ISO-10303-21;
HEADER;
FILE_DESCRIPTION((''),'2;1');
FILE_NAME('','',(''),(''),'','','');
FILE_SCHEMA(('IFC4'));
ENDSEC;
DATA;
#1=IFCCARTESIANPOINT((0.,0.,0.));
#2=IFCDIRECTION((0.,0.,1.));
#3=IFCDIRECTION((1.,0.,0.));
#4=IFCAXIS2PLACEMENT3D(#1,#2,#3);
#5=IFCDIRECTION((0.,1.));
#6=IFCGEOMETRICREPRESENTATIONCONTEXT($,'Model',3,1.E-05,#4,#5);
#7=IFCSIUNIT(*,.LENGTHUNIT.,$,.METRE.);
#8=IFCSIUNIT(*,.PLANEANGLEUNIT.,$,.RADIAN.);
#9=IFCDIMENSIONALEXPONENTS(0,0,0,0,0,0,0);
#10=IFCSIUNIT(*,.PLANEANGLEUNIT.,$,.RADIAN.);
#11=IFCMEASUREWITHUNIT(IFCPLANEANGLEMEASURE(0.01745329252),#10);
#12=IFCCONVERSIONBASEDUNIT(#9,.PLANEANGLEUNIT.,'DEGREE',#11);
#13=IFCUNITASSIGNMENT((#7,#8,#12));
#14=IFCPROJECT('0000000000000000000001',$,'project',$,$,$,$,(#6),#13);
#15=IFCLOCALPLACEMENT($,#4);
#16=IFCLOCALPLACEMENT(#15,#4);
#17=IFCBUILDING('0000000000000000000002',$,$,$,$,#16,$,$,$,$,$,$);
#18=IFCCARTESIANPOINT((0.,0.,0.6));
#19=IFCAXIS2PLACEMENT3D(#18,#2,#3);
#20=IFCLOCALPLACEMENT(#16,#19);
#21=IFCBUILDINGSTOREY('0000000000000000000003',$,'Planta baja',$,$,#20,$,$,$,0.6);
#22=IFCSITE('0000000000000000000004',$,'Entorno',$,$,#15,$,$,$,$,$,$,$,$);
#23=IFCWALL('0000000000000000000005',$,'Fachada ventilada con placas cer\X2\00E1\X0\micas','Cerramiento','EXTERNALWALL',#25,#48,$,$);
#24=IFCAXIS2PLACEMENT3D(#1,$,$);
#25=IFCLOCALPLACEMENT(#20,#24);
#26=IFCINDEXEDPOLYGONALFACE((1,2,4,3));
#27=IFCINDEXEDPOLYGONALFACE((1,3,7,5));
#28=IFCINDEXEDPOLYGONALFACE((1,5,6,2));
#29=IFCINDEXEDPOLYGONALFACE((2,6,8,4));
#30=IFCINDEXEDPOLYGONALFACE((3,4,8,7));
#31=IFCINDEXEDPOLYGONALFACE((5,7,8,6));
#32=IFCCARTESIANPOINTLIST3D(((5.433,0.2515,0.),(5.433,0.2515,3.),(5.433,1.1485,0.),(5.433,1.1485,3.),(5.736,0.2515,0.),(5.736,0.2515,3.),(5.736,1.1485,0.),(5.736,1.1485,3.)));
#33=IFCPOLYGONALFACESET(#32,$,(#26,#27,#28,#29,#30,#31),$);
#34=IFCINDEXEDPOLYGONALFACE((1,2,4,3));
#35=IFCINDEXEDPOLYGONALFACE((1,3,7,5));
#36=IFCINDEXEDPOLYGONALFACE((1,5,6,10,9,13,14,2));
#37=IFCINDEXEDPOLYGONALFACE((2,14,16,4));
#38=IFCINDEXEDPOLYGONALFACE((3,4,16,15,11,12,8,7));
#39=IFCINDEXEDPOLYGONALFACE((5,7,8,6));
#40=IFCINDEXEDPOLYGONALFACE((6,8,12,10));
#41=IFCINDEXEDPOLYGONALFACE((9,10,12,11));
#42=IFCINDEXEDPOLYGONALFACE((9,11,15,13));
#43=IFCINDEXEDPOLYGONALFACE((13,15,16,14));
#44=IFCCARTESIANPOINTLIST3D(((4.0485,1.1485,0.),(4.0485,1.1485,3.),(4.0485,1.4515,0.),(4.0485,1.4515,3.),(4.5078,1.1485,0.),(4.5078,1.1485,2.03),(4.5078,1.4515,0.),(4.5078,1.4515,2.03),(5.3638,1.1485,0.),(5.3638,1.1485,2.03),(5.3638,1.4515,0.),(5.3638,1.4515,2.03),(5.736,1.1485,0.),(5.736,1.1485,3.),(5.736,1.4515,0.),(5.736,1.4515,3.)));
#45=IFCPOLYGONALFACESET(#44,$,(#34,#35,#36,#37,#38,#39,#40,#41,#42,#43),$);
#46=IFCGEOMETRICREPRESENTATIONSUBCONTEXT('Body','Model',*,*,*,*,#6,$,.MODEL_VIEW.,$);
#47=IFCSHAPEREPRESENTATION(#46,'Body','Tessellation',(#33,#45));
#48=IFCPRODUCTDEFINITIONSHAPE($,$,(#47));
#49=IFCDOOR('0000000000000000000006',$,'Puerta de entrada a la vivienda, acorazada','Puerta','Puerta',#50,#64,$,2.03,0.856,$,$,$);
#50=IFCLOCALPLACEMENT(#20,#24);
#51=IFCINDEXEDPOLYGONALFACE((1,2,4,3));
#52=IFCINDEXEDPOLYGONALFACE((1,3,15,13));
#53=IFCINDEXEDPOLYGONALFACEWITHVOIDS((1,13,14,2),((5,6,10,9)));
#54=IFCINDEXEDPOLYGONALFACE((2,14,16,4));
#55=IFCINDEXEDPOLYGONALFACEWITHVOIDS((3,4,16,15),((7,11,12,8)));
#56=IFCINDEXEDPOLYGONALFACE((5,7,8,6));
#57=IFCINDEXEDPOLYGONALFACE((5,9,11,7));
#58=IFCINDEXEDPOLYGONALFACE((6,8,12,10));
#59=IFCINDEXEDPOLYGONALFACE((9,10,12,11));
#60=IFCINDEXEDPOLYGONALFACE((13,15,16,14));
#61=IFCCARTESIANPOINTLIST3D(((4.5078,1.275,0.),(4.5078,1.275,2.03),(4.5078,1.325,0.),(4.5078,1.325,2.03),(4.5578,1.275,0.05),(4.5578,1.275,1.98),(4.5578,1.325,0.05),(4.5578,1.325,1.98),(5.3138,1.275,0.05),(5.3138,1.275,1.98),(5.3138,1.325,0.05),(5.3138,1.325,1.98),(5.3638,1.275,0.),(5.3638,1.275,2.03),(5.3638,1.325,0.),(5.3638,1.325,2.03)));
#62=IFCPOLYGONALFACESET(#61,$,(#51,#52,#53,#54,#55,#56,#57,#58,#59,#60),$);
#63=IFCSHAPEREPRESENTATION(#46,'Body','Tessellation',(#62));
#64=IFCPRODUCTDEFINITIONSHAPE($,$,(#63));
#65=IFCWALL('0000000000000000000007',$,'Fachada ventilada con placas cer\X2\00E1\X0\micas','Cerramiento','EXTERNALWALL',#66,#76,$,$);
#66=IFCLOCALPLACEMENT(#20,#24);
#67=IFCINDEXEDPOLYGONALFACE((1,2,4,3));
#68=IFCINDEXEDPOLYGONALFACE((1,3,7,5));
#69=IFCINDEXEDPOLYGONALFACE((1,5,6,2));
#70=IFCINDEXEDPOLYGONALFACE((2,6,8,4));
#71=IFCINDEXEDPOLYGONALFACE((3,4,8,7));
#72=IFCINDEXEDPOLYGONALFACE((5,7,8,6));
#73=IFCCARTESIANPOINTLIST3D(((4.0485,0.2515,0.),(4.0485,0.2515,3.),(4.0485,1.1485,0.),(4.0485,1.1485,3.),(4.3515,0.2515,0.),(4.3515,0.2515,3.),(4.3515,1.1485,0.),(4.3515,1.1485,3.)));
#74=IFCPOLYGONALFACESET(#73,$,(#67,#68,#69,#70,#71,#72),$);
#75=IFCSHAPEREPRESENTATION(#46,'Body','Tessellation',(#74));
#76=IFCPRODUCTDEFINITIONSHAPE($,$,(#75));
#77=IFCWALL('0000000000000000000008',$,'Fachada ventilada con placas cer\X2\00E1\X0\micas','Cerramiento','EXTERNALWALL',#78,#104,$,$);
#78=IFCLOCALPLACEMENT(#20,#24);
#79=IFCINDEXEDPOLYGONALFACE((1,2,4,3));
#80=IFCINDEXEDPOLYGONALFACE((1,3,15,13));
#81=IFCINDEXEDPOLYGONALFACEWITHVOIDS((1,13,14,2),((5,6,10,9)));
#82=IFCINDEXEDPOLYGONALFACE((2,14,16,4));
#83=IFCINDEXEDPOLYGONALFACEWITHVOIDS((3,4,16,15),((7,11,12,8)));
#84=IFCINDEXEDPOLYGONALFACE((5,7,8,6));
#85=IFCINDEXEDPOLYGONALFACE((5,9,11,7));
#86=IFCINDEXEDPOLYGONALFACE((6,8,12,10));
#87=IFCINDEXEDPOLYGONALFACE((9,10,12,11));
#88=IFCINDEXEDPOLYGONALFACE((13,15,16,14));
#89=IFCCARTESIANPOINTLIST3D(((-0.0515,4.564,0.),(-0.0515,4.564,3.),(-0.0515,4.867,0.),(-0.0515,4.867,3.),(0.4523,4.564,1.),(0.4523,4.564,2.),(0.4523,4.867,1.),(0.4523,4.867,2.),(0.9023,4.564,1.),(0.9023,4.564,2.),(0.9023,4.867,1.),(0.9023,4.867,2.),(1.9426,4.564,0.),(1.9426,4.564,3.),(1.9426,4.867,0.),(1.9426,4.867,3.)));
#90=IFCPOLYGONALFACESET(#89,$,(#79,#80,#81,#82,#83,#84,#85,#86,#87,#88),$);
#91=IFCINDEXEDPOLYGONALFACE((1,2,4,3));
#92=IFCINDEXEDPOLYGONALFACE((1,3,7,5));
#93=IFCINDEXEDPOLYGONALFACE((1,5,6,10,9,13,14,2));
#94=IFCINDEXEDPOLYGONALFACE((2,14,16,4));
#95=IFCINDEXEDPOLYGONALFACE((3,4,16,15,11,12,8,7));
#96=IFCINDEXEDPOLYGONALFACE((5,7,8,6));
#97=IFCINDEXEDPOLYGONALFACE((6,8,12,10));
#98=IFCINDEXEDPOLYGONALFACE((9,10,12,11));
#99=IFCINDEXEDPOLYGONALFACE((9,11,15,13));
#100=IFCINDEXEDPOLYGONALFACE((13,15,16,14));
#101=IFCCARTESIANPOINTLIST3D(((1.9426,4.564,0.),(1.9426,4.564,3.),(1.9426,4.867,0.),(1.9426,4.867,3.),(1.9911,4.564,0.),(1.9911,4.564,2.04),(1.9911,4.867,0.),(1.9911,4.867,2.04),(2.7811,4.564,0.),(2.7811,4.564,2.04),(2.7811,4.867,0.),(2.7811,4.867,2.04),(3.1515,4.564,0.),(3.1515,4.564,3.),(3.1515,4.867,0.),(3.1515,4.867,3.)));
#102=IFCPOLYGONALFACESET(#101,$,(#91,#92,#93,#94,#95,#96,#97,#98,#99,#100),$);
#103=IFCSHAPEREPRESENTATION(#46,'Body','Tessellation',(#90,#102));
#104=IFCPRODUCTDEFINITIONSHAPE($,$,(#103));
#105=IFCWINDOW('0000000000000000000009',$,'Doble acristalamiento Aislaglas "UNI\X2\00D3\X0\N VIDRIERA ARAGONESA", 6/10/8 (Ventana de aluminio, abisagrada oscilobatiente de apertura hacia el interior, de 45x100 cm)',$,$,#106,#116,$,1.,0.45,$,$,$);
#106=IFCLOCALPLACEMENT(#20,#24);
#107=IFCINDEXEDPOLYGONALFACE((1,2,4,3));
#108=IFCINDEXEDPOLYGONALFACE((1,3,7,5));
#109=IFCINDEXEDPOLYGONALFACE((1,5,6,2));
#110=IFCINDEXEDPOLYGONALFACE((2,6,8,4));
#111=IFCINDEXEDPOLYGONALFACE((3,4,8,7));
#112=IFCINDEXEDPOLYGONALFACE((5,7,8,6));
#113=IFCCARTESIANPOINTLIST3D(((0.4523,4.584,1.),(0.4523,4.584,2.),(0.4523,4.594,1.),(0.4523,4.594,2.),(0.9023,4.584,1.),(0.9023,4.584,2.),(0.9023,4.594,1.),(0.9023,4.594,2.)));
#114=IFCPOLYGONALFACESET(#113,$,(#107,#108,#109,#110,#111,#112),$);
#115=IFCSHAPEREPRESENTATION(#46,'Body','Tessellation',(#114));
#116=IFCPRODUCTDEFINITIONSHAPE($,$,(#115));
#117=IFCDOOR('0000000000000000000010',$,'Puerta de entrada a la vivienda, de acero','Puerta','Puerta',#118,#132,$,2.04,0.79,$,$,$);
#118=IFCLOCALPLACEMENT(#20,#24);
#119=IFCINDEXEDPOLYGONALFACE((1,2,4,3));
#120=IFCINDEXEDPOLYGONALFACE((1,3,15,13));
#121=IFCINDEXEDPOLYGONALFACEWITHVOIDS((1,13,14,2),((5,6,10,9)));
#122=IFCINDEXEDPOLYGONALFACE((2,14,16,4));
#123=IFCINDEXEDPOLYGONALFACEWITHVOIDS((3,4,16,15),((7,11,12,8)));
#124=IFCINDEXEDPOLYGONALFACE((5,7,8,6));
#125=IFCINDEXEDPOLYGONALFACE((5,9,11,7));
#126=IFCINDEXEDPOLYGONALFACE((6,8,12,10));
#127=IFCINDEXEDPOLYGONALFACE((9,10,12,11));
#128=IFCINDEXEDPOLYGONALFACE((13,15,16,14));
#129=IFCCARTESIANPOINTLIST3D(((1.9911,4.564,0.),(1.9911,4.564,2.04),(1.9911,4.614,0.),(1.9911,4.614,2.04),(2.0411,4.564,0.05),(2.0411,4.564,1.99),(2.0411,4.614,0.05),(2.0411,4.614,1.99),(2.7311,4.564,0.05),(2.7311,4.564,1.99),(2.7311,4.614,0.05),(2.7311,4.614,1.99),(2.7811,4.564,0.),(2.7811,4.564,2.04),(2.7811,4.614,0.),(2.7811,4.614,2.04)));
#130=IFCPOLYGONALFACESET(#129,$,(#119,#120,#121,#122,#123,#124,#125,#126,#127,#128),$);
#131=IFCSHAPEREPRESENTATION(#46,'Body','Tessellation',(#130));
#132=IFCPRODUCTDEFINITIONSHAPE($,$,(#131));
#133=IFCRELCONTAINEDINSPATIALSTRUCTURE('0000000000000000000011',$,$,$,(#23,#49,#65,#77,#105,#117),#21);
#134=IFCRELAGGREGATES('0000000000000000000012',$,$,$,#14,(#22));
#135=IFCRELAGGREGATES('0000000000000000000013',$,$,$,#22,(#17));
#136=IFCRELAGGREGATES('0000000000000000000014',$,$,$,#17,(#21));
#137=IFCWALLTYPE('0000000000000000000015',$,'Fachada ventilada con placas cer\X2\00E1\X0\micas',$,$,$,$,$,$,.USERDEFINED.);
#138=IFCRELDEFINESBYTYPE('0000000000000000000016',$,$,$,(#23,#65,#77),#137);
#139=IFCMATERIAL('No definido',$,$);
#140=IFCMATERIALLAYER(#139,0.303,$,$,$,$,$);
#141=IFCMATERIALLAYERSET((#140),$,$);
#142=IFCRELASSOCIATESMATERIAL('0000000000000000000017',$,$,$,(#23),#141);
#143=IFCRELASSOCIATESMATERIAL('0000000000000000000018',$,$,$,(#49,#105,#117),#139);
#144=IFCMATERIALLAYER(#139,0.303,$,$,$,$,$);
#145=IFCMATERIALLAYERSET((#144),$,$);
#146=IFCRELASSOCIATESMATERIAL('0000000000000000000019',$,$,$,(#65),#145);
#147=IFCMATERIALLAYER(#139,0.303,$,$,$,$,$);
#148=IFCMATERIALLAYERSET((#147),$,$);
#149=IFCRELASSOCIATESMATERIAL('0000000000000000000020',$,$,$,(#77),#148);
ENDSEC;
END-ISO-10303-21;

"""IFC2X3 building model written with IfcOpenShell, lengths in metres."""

from ifc_helpers import new_model, entity, si_unit, converted_unit, direction, frame, origin_with_axes, origin_2d_with_axis, place, context, subcontext, project, spatial, polyline, rectangle, hollow_rectangle, outline, extrude, shape, material, layer, layer_set, layer_usage, type_object, element, fill, save


model = new_model("IFC2X3")

# Units and contexts
model_context = context("Model", 3, precision=1e-05, world=origin_with_axes(), true_north=direction((0.0, 1.0)))
body_context = subcontext(model_context, "Body", "Model", "MODEL_VIEW")
footprint_context = subcontext(model_context, "FootPrint", "Model", "MODEL_VIEW")
ifc_project = project(units=[si_unit("LENGTHUNIT", "METRE"), si_unit("PLANEANGLEUNIT", "RADIAN"), converted_unit("PLANEANGLEUNIT", "DEGREE", entity("IfcPlaneAngleMeasure", 0.01745329252), si_unit("PLANEANGLEUNIT", "RADIAN"), dimensions=[0, 0, 0, 0, 0, 0, 0])], contexts=[model_context])

# Site, building, storey
site_placement = place(None, origin_with_axes())
site = spatial("IfcSite", under=ifc_project, at=site_placement, Name="Entorno")
building_placement = place(site_placement, origin_with_axes())
building = spatial("IfcBuilding", under=site, at=building_placement)
storey_placement = place(building_placement, frame((0.0, 0.0, 0.6), z_axis=(0.0, 0.0, 1.0), x_axis=(1.0, 0.0, 0.0)))
storey = spatial("IfcBuildingStorey", under=building, at=storey_placement, Name="Planta baja", Elevation=0.6)

# Shared definitions
ifc_material = material(Name="No definido")

# Wall, opening, door
ifc_layer_1 = layer(ifc_material, 0.303)
ifc_layer_set_1 = layer_set([ifc_layer_1])
ifc_layer_usage_1 = layer_usage(ifc_layer_set_1, "AXIS2", "POSITIVE", -0.1515)
wall_type_1 = type_object("IfcWallType", Name="Fachada ventilada con placas cerámicas", PredefinedType="USERDEFINED")
wall_1_placement = place(storey_placement, frame((5.5845, 0.1, 0.0), z_axis=(0.0, 0.0, 1.0), x_axis=(0.0, 1.0, 0.0)))
wall_1 = element("IfcWall", 1, at=wall_1_placement, inside=storey, type_object=wall_type_1, material=ifc_layer_usage_1, Name="Fachada ventilada con placas cerámicas", Description="Cerramiento", ObjectType="EXTERNALWALL", context=body_context, shape_type="SolidModel", body=[
    extrude(outline(polyline([(-0.4485, -1.5), (0.4485, -1.5), (0.4485, 1.5), (-0.4485, 1.5), (-0.4485, -1.5)])), frame((0.6, 0.1515, 1.5), z_axis=(0.0, -1.0, 0.0), x_axis=(1.0, 0.0, 0.0)), (0.0, 0.0, 1.0), 0.303),
    extrude(outline(polyline([(-0.8438, -1.5), (0.8438, -1.5), (0.8438, 1.5), (-0.8438, 1.5), (-0.8438, -1.5)])), frame((1.0485, 0.6923, 1.5), z_axis=(1.0, 0.0, 0.0), x_axis=(0.0, 1.0, 0.0)), (0.0, 0.0, 1.0), 0.303),
])
opening_1_placement = place(wall_1_placement, frame((1.2, 0.6487, 1.015), z_axis=(0.0, 0.0, 1.0), x_axis=(0.0, 1.0, 0.0)))
cartesian_point_1 = entity("IfcCartesianPoint", [-0.428, -0.1515])
opening_1 = element("IfcOpeningElement", 2, at=opening_1_placement, cuts=wall_1, ObjectType="No definido", shapes=[
    shape(body_context, "Body", "SweptSolid", [extrude(rectangle(XDim=2.03, YDim=0.856, at=origin_2d_with_axis()), frame((0.0, -0.1515, 0.0), z_axis=(0.0, 1.0, 0.0), x_axis=(0.0, 0.0, 1.0)), (0.0, 0.0, 1.0), 0.303)]),
    shape(footprint_context, "FootPrint", "GeometricCurveSet", [entity("IfcGeometricCurveSet", [entity("IfcPolyline", [cartesian_point_1, entity("IfcCartesianPoint", [0.428, -0.1515]), entity("IfcCartesianPoint", [0.428, 0.1515]), entity("IfcCartesianPoint", [-0.428, 0.1515]), cartesian_point_1])])]),
])
door_1_placement = place(opening_1_placement, origin_with_axes())
door_1 = element("IfcDoor", 3, at=door_1_placement, inside=storey, material=ifc_material, Name="Puerta de entrada a la vivienda, acorazada", Description="Puerta", ObjectType="Puerta", OverallHeight=2.03, OverallWidth=0.856, context=body_context, shape_type="SweptSolid", body=[
    extrude(hollow_rectangle(XDim=0.856, YDim=2.03, WallThickness=0.05, InnerFilletRadius=0.0, OuterFilletRadius=0.0, at=origin_2d_with_axis()), frame((0.0, 0.025, 0.0), z_axis=(0.0, -1.0, 0.0), x_axis=(1.0, 0.0, 0.0)), (0.0, 0.0, 1.0), 0.05),
])
fill(opening_1, door_1)

# Wall
ifc_layer_2 = layer(ifc_material, 0.303)
ifc_layer_set_2 = layer_set([ifc_layer_2])
ifc_layer_usage_2 = layer_usage(ifc_layer_set_2, "AXIS2", "POSITIVE", -0.1515)
wall_2_placement = place(storey_placement, frame((4.2, 1.3, 0.0), z_axis=(0.0, 0.0, 1.0), x_axis=(0.0, -1.0, 0.0)))
element("IfcWall", 4, at=wall_2_placement, inside=storey, type_object=wall_type_1, material=ifc_layer_usage_2, Name="Fachada ventilada con placas cerámicas", Description="Cerramiento", ObjectType="EXTERNALWALL", context=body_context, shape_type="SolidModel", body=[
    extrude(outline(polyline([(-0.4485, -1.5), (0.4485, -1.5), (0.4485, 1.5), (-0.4485, 1.5), (-0.4485, -1.5)])), frame((0.6, 0.1515, 1.5), z_axis=(0.0, -1.0, 0.0), x_axis=(1.0, 0.0, 0.0)), (0.0, 0.0, 1.0), 0.303),
])

# Wall, openings, window, door
ifc_layer_3 = layer(ifc_material, 0.303)
ifc_layer_set_3 = layer_set([ifc_layer_3])
ifc_layer_usage_3 = layer_usage(ifc_layer_set_3, "AXIS2", "POSITIVE", -0.1515)
wall_3_placement = place(storey_placement, frame((0.1, 4.7155, 0.0), z_axis=(0.0, 0.0, 1.0), x_axis=(1.0, 0.0, 0.0)))
wall_3 = element("IfcWall", 5, at=wall_3_placement, inside=storey, type_object=wall_type_1, material=ifc_layer_usage_3, Name="Fachada ventilada con placas cerámicas", Description="Cerramiento", ObjectType="EXTERNALWALL", context=body_context, shape_type="SolidModel", body=[
    extrude(outline(polyline([(-0.997, -1.5), (0.997, -1.5), (0.997, 1.5), (-0.997, 1.5), (-0.997, -1.5)])), frame((0.8456, 0.1515, 1.5), z_axis=(0.0, -1.0, 0.0), x_axis=(1.0, 0.0, 0.0)), (0.0, 0.0, 1.0), 0.303),
    extrude(outline(polyline([(-0.6045, -1.5), (0.6045, -1.5), (0.6045, 1.5), (-0.6045, 1.5), (-0.6045, -1.5)])), frame((2.447, 0.1515, 1.5), z_axis=(0.0, -1.0, 0.0), x_axis=(1.0, 0.0, 0.0)), (0.0, 0.0, 1.0), 0.303),
])
opening_2_placement = place(wall_3_placement, frame((0.5773, 0.0, 1.5), z_axis=(0.0, 0.0, 1.0), x_axis=(1.0, 0.0, 0.0)))
cartesian_point_2 = entity("IfcCartesianPoint", [-0.225, -0.1515])
opening_2 = element("IfcOpeningElement", 6, at=opening_2_placement, cuts=wall_3, ObjectType="No definido", shapes=[
    shape(body_context, "Body", "SweptSolid", [extrude(rectangle(XDim=1.0, YDim=0.45, at=origin_2d_with_axis()), frame((0.0, -0.1515, 0.0), z_axis=(0.0, 1.0, 0.0), x_axis=(0.0, 0.0, 1.0)), (0.0, 0.0, 1.0), 0.303)]),
    shape(footprint_context, "FootPrint", "GeometricCurveSet", [entity("IfcGeometricCurveSet", [entity("IfcPolyline", [cartesian_point_2, entity("IfcCartesianPoint", [0.225, -0.1515]), entity("IfcCartesianPoint", [0.225, 0.1515]), entity("IfcCartesianPoint", [-0.225, 0.1515]), cartesian_point_2])])]),
])
opening_3_placement = place(wall_3_placement, frame((2.2861, 0.0, 1.02), z_axis=(0.0, 0.0, 1.0), x_axis=(1.0, 0.0, 0.0)))
cartesian_point_3 = entity("IfcCartesianPoint", [-0.395, -0.1515])
opening_3 = element("IfcOpeningElement", 7, at=opening_3_placement, cuts=wall_3, ObjectType="No definido", shapes=[
    shape(body_context, "Body", "SweptSolid", [extrude(rectangle(XDim=2.04, YDim=0.79, at=origin_2d_with_axis()), frame((0.0, -0.1515, 0.0), z_axis=(0.0, 1.0, 0.0), x_axis=(0.0, 0.0, 1.0)), (0.0, 0.0, 1.0), 0.303)]),
    shape(footprint_context, "FootPrint", "GeometricCurveSet", [entity("IfcGeometricCurveSet", [entity("IfcPolyline", [cartesian_point_3, entity("IfcCartesianPoint", [0.395, -0.1515]), entity("IfcCartesianPoint", [0.395, 0.1515]), entity("IfcCartesianPoint", [-0.395, 0.1515]), cartesian_point_3])])]),
])
window_1_placement = place(opening_2_placement, frame((0.0, -0.1265, 0.0), z_axis=(0.0, 0.0, 1.0), x_axis=(1.0, 0.0, 0.0)))
window_1 = element("IfcWindow", 8, at=window_1_placement, inside=storey, material=ifc_material, Name="Doble acristalamiento Aislaglas \"UNIÓN VIDRIERA ARAGONESA\", 6/10/8 (Ventana de aluminio, abisagrada oscilobatiente de apertura hacia el interior, de 45x100 cm)", OverallHeight=1.0, OverallWidth=0.45, context=body_context, shape_type="SweptSolid", body=[
    extrude(rectangle(XDim=0.45, YDim=1.0, at=origin_2d_with_axis()), frame((0.0, 0.005, 0.0), z_axis=(0.0, -1.0, 0.0), x_axis=(1.0, 0.0, 0.0)), (0.0, 0.0, 1.0), 0.01),
])
fill(opening_2, window_1)
door_2_placement = place(opening_3_placement, frame((0.0, -0.1265, 0.0), z_axis=(0.0, 0.0, 1.0), x_axis=(1.0, 0.0, 0.0)))
door_2 = element("IfcDoor", 9, at=door_2_placement, inside=storey, material=ifc_material, Name="Puerta de entrada a la vivienda, de acero", Description="Puerta", ObjectType="Puerta", OverallHeight=2.04, OverallWidth=0.79, context=body_context, shape_type="SweptSolid", body=[
    extrude(hollow_rectangle(XDim=0.79, YDim=2.04, WallThickness=0.05, InnerFilletRadius=0.0, OuterFilletRadius=0.0, at=origin_2d_with_axis()), frame((0.0, 0.025, 0.0), z_axis=(0.0, -1.0, 0.0), x_axis=(1.0, 0.0, 0.0)), (0.0, 0.0, 1.0), 0.05),
])
fill(opening_3, door_2)

save(model, "model.ifc")
